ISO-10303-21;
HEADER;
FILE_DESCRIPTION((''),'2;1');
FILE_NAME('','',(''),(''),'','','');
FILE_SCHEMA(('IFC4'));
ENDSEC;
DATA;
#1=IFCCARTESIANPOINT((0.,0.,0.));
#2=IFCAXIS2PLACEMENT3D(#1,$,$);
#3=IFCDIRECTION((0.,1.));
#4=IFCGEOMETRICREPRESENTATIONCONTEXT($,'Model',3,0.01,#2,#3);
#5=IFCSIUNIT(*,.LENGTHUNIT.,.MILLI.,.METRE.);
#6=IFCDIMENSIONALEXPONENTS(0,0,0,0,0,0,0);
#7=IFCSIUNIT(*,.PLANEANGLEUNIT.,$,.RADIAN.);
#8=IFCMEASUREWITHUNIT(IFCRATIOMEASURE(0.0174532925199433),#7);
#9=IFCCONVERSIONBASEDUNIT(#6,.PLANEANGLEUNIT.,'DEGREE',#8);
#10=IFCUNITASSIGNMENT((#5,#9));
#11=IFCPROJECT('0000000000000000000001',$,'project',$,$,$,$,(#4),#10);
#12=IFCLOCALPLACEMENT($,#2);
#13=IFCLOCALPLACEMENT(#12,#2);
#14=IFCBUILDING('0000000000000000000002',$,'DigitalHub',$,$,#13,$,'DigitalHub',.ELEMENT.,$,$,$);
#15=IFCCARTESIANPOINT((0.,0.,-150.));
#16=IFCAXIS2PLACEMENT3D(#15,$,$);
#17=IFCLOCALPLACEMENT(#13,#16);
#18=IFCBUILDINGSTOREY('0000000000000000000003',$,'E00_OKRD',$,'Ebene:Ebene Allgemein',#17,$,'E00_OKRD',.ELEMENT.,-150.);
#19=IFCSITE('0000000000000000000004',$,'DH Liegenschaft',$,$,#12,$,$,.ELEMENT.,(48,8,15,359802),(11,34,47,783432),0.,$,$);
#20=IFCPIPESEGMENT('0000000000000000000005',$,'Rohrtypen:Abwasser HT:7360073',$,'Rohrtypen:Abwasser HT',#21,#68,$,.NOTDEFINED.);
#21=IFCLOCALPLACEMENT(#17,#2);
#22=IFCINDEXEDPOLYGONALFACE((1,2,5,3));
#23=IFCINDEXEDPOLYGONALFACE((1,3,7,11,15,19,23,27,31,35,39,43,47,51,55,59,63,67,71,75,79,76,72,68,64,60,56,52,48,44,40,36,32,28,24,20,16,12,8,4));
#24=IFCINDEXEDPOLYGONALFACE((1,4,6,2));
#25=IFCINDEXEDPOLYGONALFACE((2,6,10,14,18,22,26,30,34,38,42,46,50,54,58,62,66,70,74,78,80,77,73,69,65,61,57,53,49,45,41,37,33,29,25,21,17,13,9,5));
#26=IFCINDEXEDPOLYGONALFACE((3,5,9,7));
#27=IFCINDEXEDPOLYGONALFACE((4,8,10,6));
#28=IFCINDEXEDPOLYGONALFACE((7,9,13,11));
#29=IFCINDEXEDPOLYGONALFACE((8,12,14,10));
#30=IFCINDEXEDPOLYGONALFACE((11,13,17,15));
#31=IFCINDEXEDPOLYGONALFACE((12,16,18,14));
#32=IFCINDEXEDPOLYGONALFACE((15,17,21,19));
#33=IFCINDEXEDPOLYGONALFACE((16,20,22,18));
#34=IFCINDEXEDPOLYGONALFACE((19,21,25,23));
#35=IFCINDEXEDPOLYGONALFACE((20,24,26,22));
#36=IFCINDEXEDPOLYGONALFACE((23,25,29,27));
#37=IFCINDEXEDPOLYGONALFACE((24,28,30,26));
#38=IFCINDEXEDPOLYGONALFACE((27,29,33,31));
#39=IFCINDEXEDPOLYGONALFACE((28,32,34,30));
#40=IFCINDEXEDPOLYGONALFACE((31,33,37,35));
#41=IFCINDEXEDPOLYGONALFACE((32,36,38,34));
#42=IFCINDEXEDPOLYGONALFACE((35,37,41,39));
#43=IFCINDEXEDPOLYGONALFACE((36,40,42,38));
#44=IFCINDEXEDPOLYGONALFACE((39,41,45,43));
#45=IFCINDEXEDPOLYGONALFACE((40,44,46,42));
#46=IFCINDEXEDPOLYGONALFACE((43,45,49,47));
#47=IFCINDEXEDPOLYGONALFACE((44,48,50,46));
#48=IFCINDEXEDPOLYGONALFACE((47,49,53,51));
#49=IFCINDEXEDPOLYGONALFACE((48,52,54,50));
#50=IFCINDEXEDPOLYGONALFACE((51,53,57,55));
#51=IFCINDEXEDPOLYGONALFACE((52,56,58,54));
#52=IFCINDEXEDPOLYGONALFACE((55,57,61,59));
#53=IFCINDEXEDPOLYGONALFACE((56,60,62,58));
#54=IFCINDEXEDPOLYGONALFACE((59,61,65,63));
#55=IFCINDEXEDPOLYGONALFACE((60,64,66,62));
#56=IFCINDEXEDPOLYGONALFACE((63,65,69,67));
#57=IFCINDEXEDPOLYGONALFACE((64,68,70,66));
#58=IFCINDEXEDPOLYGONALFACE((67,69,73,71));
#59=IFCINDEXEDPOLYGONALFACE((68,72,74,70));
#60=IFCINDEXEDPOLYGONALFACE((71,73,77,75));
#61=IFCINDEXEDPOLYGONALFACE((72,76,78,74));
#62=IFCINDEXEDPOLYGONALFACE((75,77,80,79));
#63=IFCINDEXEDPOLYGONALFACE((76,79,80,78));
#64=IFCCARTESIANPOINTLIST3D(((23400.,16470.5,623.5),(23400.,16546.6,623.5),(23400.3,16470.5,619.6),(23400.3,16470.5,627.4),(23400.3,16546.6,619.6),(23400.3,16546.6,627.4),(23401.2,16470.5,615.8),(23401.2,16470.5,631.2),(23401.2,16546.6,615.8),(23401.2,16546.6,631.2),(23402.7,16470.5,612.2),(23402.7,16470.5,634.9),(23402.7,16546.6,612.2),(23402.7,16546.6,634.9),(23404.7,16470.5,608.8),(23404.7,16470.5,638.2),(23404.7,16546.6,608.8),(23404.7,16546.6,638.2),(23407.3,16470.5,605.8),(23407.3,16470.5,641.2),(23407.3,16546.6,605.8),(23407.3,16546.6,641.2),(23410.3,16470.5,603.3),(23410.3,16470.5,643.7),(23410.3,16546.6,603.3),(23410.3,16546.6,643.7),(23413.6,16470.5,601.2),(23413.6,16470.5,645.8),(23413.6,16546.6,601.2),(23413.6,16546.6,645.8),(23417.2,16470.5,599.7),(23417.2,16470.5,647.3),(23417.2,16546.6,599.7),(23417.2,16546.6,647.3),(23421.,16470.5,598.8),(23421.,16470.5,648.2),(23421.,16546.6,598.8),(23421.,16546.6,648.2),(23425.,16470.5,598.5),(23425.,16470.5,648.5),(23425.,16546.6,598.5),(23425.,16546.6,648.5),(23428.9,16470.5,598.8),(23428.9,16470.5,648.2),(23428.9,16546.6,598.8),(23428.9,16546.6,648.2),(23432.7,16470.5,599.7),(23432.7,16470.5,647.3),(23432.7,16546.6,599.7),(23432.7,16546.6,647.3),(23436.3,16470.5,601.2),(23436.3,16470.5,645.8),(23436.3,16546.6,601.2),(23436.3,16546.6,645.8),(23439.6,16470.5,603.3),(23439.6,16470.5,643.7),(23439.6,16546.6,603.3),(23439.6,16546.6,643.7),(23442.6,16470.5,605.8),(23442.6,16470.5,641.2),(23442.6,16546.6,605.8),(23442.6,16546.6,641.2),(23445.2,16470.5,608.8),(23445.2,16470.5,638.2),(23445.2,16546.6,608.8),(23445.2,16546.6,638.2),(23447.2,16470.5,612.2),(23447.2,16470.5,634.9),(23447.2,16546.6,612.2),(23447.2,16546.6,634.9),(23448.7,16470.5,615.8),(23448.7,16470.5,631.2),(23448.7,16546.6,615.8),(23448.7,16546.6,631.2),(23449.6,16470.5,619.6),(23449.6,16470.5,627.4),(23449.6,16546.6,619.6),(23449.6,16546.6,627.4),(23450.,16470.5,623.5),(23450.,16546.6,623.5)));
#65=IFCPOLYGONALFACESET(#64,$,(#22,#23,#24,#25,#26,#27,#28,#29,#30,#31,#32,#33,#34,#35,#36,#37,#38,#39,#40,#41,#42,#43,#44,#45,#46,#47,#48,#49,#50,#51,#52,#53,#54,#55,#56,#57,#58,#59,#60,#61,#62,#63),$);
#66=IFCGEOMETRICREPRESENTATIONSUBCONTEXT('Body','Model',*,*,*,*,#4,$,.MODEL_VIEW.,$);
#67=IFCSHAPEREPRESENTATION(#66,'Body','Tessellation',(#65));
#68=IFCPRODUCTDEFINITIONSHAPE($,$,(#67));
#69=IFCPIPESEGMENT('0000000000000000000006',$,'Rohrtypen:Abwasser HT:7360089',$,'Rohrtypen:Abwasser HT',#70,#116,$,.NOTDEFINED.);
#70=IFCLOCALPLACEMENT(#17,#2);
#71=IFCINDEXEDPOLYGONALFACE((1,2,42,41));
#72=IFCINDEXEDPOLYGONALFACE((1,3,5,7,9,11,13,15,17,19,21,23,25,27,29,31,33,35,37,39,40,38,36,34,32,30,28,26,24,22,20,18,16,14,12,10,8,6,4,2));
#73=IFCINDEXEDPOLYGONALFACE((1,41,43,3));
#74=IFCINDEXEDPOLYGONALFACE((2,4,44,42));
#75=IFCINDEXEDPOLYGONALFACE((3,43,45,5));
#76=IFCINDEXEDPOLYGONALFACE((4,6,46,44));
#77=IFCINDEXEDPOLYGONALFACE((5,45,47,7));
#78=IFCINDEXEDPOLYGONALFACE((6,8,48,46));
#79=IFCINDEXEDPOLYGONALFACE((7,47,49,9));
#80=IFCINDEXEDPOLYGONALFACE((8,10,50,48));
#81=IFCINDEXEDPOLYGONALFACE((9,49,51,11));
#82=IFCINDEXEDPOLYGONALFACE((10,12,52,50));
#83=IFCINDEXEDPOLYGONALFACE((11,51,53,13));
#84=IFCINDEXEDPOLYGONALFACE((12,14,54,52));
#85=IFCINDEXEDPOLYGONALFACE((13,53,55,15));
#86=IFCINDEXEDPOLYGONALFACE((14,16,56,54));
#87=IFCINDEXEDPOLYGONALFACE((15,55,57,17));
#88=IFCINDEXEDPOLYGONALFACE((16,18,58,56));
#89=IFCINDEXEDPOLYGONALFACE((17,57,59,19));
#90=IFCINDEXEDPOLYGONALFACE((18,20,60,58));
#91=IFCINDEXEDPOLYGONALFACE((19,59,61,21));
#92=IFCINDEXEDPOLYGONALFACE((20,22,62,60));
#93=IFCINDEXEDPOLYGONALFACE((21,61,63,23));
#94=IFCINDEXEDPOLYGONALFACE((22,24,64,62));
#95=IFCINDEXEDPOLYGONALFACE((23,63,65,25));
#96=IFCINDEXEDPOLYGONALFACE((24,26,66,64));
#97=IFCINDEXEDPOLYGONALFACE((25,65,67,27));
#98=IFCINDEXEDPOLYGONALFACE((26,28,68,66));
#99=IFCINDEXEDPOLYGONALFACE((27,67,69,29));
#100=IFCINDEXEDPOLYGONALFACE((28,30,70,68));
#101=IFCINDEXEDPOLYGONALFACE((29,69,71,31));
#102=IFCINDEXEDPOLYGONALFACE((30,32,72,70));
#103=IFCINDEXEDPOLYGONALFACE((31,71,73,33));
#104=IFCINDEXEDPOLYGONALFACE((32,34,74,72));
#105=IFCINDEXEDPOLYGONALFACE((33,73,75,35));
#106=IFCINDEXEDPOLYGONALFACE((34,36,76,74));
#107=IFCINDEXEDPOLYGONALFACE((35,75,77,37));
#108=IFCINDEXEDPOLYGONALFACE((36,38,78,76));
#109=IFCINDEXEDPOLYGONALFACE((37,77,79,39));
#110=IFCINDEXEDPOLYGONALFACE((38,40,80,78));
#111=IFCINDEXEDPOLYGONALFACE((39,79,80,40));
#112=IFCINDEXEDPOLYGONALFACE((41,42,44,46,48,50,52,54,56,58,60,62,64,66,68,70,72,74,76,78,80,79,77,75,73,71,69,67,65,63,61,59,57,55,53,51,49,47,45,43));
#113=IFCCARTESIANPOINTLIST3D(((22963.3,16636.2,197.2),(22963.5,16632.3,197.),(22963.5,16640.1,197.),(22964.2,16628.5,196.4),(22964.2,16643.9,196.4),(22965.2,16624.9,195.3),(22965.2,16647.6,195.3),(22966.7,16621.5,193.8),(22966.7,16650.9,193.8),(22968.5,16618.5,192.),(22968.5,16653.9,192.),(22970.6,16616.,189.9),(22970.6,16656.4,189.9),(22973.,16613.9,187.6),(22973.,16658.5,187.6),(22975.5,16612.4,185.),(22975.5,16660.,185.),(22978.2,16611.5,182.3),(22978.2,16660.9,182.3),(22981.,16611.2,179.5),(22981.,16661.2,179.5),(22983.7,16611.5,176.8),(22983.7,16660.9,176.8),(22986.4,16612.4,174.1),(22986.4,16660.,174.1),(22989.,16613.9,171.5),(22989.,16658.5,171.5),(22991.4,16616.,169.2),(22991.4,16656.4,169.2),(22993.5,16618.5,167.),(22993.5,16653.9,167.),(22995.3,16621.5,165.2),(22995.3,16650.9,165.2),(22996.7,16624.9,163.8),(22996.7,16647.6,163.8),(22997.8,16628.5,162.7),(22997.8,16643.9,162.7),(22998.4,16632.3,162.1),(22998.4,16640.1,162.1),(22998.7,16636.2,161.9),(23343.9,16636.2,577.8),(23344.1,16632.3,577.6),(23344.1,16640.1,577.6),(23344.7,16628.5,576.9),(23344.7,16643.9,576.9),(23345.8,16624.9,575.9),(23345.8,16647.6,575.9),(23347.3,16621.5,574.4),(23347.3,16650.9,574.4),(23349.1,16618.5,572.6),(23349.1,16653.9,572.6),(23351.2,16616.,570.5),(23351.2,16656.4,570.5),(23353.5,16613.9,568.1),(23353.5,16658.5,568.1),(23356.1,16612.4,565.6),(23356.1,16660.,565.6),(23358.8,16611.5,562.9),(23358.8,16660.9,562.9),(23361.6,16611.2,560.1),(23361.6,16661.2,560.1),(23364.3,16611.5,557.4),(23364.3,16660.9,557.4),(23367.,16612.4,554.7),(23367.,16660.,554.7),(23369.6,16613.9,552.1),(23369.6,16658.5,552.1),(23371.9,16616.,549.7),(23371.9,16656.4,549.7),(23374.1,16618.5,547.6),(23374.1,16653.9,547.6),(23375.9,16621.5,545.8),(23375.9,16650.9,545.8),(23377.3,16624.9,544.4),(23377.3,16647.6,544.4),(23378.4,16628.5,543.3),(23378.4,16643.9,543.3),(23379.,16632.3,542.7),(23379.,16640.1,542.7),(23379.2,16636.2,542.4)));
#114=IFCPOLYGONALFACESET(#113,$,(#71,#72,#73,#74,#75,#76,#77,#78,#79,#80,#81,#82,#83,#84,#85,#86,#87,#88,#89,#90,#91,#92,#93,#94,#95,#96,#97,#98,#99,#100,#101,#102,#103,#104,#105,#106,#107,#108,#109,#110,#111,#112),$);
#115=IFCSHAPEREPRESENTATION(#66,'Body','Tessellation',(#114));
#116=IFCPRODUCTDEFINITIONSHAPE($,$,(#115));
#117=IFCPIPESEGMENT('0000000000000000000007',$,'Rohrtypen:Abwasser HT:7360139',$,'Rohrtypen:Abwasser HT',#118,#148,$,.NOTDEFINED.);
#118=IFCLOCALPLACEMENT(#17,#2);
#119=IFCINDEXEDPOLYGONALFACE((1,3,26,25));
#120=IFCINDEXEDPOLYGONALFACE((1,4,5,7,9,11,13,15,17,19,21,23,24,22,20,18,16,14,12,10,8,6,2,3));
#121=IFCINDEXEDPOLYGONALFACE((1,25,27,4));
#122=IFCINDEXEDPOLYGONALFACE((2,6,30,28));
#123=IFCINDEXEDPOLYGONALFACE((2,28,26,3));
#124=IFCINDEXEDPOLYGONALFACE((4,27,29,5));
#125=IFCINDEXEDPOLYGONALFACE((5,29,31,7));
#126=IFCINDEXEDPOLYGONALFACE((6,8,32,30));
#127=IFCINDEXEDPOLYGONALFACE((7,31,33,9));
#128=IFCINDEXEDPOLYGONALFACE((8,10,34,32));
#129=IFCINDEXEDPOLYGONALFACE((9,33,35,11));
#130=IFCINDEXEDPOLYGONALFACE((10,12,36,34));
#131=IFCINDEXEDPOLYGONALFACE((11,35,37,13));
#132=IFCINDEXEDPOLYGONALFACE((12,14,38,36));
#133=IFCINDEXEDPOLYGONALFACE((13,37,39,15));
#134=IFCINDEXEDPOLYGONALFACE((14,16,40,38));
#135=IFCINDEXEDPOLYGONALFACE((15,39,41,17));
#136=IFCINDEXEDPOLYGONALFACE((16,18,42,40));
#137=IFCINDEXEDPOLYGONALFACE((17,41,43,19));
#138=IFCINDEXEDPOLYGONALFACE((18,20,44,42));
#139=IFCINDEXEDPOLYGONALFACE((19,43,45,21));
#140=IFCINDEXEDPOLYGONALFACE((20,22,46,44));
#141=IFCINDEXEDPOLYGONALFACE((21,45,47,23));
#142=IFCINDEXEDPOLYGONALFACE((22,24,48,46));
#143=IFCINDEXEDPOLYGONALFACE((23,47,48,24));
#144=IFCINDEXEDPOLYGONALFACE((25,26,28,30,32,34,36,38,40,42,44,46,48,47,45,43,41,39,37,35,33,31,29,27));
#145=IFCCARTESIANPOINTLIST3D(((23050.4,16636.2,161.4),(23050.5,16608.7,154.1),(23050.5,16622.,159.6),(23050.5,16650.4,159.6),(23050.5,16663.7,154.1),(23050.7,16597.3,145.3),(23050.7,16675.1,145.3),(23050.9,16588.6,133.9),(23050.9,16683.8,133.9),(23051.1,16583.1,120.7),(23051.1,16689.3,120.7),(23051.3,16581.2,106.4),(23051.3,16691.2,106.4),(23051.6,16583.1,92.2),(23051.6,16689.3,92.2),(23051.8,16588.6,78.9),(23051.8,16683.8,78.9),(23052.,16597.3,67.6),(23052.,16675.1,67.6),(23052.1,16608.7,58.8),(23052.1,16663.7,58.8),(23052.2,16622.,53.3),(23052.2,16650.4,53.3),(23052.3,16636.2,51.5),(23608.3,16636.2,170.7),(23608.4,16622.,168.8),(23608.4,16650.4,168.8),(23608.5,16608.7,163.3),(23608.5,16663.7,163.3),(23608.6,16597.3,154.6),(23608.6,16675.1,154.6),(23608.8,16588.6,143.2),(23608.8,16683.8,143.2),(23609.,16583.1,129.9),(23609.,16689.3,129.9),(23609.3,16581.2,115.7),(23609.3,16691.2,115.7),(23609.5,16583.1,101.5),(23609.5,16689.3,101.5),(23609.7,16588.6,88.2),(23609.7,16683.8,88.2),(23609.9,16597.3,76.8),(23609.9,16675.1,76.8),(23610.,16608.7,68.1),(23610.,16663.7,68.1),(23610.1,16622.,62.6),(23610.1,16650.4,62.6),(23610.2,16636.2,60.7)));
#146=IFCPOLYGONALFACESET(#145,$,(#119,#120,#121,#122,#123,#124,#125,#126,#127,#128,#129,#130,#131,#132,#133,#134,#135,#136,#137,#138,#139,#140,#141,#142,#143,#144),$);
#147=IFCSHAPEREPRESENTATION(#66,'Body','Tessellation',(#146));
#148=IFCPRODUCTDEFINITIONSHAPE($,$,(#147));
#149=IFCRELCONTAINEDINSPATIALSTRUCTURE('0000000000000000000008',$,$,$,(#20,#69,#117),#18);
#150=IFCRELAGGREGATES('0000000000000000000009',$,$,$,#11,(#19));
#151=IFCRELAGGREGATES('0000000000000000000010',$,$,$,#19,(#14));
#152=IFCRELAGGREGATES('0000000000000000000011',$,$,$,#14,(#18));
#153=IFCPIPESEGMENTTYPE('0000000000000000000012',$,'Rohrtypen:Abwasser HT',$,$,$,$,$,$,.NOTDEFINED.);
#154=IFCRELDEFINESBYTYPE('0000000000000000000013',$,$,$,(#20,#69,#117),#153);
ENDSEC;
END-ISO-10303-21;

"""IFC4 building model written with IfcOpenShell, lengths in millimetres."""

from ifc_helpers import new_model, entity, si_unit, converted_unit, direction, frame, origin, place, context, subcontext, project, spatial, indexed_curve, outline, extrude, type_object, element, save


model = new_model("IFC4")

# Units and contexts
model_context = context("Model", 3, precision=0.01, world=origin(), true_north=direction((0.0, 1.0)))
body_context = subcontext(model_context, "Body", "Model", "MODEL_VIEW")
ifc_project = project(units=[si_unit("LENGTHUNIT", "METRE", prefix="MILLI"), converted_unit("PLANEANGLEUNIT", "DEGREE", entity("IfcRatioMeasure", 0.0174532925199433), si_unit("PLANEANGLEUNIT", "RADIAN"), dimensions=[0, 0, 0, 0, 0, 0, 0])], contexts=[model_context])

# Site, building, storey
site_placement = place(None, origin())
site = spatial("IfcSite", under=ifc_project, at=site_placement, Name="DH Liegenschaft", CompositionType="ELEMENT", RefLatitude=(48, 8, 15, 359802), RefLongitude=(11, 34, 47, 783432), RefElevation=0.0)
building_placement = place(site_placement, origin())
building = spatial("IfcBuilding", under=site, at=building_placement, Name="DigitalHub", LongName="DigitalHub", CompositionType="ELEMENT")
storey_placement = place(building_placement, frame((0.0, 0.0, -150.0)))
storey = spatial("IfcBuildingStorey", under=building, at=storey_placement, Name="E00_OKRD", ObjectType="Ebene:Ebene Allgemein", LongName="E00_OKRD", CompositionType="ELEMENT", Elevation=-150.0)

# Pipe segments
pipe_segment_type_1 = type_object("IfcPipeSegmentType", Name="Rohrtypen:Abwasser HT", PredefinedType="NOTDEFINED")
pipe_segment_1_placement = place(storey_placement, frame((23398.4, 16470.5, 596.9)))
element("IfcPipeSegment", 1, at=pipe_segment_1_placement, inside=storey, type_object=pipe_segment_type_1, Name="Rohrtypen:Abwasser HT:7360073", ObjectType="Rohrtypen:Abwasser HT", PredefinedType="NOTDEFINED", context=body_context, shape_type="SweptSolid", body=[
    extrude(outline(indexed_curve([(25.0, 0.0), (24.7, 3.9), (23.8, 7.7), (22.3, 11.3), (20.2, 14.7), (17.7, 17.7), (14.7, 20.2), (11.3, 22.3), (7.7, 23.8), (3.9, 24.7), (0.0, 25.0), (-3.9, 24.7), (-7.7, 23.8), (-11.3, 22.3), (-14.7, 20.2), (-17.7, 17.7), (-20.2, 14.7), (-22.3, 11.3), (-23.8, 7.7), (-24.7, 3.9), (-25.0, 0.0), (-24.7, -3.9), (-23.8, -7.7), (-22.3, -11.3), (-20.2, -14.7), (-17.7, -17.7), (-14.7, -20.2), (-11.3, -22.3), (-7.7, -23.8), (-3.9, -24.7), (0.0, -25.0), (3.9, -24.7), (7.7, -23.8), (11.3, -22.3), (14.7, -20.2), (17.7, -17.7), (20.2, -14.7), (22.3, -11.3), (23.8, -7.7), (24.7, -3.9), (25.0, 0.0)], self_intersect=False)), frame((26.6, 0.0, 26.6), z_axis=(0.0, 1.0, 0.0), x_axis=(1.0, 0.0, 0.0)), (0.0, 0.0, 1.0), 76.0),
])
pipe_segment_2_placement = place(storey_placement, frame((22961.7, 16609.6, 160.3)))
element("IfcPipeSegment", 2, at=pipe_segment_2_placement, inside=storey, type_object=pipe_segment_type_1, Name="Rohrtypen:Abwasser HT:7360089", ObjectType="Rohrtypen:Abwasser HT", PredefinedType="NOTDEFINED", context=body_context, shape_type="SweptSolid", body=[
    extrude(outline(indexed_curve([(25.0, 0.0), (24.7, 3.9), (23.8, 7.7), (22.3, 11.3), (20.2, 14.7), (17.7, 17.7), (14.7, 20.2), (11.3, 22.3), (7.7, 23.8), (3.9, 24.7), (0.0, 25.0), (-3.9, 24.7), (-7.7, 23.8), (-11.3, 22.3), (-14.7, 20.2), (-17.7, 17.7), (-20.2, 14.7), (-22.3, 11.3), (-23.8, 7.7), (-24.7, 3.9), (-25.0, 0.0), (-24.7, -3.9), (-23.8, -7.7), (-22.3, -11.3), (-20.2, -14.7), (-17.7, -17.7), (-14.7, -20.2), (-11.3, -22.3), (-7.7, -23.8), (-3.9, -24.7), (0.0, -25.0), (3.9, -24.7), (7.7, -23.8), (11.3, -22.3), (14.7, -20.2), (17.7, -17.7), (20.2, -14.7), (22.3, -11.3), (23.8, -7.7), (24.7, -3.9), (25.0, 0.0)], self_intersect=False)), frame((19.3, 26.6, 19.3), z_axis=(0.707107, 0.0, 0.707107), x_axis=(0.0, 1.0, 0.0)), (0.0, 0.0, 1.0), 538.2),
])
pipe_segment_3_placement = place(storey_placement, frame((23048.8, 16579.6, 49.9)))
element("IfcPipeSegment", 3, at=pipe_segment_3_placement, inside=storey, type_object=pipe_segment_type_1, Name="Rohrtypen:Abwasser HT:7360139", ObjectType="Rohrtypen:Abwasser HT", PredefinedType="NOTDEFINED", context=body_context, shape_type="SweptSolid", body=[
    extrude(outline(indexed_curve([(-7.2, -54.5), (7.2, -54.5), (21.0, -50.8), (33.5, -43.6), (43.6, -33.5), (50.8, -21.0), (54.5, -7.2), (54.5, 7.2), (50.8, 21.0), (43.6, 33.5), (33.5, 43.6), (21.0, 50.8), (7.2, 54.5), (-7.2, 54.5), (-21.0, 50.8), (-33.5, 43.6), (-43.6, 33.5), (-50.8, 21.0), (-54.5, 7.2), (-54.5, -7.2), (-50.8, -21.0), (-43.6, -33.5), (-33.5, -43.6), (-21.0, -50.8), (-7.2, -54.5)], self_intersect=False)), frame((2.5, 56.6, 56.6), z_axis=(0.999862, 0.0, 0.016604), x_axis=(-0.016462, -0.130526, 0.991308)), (0.0, 0.0, 1.0), 558.0),
])

save(model, "model.ifc")
